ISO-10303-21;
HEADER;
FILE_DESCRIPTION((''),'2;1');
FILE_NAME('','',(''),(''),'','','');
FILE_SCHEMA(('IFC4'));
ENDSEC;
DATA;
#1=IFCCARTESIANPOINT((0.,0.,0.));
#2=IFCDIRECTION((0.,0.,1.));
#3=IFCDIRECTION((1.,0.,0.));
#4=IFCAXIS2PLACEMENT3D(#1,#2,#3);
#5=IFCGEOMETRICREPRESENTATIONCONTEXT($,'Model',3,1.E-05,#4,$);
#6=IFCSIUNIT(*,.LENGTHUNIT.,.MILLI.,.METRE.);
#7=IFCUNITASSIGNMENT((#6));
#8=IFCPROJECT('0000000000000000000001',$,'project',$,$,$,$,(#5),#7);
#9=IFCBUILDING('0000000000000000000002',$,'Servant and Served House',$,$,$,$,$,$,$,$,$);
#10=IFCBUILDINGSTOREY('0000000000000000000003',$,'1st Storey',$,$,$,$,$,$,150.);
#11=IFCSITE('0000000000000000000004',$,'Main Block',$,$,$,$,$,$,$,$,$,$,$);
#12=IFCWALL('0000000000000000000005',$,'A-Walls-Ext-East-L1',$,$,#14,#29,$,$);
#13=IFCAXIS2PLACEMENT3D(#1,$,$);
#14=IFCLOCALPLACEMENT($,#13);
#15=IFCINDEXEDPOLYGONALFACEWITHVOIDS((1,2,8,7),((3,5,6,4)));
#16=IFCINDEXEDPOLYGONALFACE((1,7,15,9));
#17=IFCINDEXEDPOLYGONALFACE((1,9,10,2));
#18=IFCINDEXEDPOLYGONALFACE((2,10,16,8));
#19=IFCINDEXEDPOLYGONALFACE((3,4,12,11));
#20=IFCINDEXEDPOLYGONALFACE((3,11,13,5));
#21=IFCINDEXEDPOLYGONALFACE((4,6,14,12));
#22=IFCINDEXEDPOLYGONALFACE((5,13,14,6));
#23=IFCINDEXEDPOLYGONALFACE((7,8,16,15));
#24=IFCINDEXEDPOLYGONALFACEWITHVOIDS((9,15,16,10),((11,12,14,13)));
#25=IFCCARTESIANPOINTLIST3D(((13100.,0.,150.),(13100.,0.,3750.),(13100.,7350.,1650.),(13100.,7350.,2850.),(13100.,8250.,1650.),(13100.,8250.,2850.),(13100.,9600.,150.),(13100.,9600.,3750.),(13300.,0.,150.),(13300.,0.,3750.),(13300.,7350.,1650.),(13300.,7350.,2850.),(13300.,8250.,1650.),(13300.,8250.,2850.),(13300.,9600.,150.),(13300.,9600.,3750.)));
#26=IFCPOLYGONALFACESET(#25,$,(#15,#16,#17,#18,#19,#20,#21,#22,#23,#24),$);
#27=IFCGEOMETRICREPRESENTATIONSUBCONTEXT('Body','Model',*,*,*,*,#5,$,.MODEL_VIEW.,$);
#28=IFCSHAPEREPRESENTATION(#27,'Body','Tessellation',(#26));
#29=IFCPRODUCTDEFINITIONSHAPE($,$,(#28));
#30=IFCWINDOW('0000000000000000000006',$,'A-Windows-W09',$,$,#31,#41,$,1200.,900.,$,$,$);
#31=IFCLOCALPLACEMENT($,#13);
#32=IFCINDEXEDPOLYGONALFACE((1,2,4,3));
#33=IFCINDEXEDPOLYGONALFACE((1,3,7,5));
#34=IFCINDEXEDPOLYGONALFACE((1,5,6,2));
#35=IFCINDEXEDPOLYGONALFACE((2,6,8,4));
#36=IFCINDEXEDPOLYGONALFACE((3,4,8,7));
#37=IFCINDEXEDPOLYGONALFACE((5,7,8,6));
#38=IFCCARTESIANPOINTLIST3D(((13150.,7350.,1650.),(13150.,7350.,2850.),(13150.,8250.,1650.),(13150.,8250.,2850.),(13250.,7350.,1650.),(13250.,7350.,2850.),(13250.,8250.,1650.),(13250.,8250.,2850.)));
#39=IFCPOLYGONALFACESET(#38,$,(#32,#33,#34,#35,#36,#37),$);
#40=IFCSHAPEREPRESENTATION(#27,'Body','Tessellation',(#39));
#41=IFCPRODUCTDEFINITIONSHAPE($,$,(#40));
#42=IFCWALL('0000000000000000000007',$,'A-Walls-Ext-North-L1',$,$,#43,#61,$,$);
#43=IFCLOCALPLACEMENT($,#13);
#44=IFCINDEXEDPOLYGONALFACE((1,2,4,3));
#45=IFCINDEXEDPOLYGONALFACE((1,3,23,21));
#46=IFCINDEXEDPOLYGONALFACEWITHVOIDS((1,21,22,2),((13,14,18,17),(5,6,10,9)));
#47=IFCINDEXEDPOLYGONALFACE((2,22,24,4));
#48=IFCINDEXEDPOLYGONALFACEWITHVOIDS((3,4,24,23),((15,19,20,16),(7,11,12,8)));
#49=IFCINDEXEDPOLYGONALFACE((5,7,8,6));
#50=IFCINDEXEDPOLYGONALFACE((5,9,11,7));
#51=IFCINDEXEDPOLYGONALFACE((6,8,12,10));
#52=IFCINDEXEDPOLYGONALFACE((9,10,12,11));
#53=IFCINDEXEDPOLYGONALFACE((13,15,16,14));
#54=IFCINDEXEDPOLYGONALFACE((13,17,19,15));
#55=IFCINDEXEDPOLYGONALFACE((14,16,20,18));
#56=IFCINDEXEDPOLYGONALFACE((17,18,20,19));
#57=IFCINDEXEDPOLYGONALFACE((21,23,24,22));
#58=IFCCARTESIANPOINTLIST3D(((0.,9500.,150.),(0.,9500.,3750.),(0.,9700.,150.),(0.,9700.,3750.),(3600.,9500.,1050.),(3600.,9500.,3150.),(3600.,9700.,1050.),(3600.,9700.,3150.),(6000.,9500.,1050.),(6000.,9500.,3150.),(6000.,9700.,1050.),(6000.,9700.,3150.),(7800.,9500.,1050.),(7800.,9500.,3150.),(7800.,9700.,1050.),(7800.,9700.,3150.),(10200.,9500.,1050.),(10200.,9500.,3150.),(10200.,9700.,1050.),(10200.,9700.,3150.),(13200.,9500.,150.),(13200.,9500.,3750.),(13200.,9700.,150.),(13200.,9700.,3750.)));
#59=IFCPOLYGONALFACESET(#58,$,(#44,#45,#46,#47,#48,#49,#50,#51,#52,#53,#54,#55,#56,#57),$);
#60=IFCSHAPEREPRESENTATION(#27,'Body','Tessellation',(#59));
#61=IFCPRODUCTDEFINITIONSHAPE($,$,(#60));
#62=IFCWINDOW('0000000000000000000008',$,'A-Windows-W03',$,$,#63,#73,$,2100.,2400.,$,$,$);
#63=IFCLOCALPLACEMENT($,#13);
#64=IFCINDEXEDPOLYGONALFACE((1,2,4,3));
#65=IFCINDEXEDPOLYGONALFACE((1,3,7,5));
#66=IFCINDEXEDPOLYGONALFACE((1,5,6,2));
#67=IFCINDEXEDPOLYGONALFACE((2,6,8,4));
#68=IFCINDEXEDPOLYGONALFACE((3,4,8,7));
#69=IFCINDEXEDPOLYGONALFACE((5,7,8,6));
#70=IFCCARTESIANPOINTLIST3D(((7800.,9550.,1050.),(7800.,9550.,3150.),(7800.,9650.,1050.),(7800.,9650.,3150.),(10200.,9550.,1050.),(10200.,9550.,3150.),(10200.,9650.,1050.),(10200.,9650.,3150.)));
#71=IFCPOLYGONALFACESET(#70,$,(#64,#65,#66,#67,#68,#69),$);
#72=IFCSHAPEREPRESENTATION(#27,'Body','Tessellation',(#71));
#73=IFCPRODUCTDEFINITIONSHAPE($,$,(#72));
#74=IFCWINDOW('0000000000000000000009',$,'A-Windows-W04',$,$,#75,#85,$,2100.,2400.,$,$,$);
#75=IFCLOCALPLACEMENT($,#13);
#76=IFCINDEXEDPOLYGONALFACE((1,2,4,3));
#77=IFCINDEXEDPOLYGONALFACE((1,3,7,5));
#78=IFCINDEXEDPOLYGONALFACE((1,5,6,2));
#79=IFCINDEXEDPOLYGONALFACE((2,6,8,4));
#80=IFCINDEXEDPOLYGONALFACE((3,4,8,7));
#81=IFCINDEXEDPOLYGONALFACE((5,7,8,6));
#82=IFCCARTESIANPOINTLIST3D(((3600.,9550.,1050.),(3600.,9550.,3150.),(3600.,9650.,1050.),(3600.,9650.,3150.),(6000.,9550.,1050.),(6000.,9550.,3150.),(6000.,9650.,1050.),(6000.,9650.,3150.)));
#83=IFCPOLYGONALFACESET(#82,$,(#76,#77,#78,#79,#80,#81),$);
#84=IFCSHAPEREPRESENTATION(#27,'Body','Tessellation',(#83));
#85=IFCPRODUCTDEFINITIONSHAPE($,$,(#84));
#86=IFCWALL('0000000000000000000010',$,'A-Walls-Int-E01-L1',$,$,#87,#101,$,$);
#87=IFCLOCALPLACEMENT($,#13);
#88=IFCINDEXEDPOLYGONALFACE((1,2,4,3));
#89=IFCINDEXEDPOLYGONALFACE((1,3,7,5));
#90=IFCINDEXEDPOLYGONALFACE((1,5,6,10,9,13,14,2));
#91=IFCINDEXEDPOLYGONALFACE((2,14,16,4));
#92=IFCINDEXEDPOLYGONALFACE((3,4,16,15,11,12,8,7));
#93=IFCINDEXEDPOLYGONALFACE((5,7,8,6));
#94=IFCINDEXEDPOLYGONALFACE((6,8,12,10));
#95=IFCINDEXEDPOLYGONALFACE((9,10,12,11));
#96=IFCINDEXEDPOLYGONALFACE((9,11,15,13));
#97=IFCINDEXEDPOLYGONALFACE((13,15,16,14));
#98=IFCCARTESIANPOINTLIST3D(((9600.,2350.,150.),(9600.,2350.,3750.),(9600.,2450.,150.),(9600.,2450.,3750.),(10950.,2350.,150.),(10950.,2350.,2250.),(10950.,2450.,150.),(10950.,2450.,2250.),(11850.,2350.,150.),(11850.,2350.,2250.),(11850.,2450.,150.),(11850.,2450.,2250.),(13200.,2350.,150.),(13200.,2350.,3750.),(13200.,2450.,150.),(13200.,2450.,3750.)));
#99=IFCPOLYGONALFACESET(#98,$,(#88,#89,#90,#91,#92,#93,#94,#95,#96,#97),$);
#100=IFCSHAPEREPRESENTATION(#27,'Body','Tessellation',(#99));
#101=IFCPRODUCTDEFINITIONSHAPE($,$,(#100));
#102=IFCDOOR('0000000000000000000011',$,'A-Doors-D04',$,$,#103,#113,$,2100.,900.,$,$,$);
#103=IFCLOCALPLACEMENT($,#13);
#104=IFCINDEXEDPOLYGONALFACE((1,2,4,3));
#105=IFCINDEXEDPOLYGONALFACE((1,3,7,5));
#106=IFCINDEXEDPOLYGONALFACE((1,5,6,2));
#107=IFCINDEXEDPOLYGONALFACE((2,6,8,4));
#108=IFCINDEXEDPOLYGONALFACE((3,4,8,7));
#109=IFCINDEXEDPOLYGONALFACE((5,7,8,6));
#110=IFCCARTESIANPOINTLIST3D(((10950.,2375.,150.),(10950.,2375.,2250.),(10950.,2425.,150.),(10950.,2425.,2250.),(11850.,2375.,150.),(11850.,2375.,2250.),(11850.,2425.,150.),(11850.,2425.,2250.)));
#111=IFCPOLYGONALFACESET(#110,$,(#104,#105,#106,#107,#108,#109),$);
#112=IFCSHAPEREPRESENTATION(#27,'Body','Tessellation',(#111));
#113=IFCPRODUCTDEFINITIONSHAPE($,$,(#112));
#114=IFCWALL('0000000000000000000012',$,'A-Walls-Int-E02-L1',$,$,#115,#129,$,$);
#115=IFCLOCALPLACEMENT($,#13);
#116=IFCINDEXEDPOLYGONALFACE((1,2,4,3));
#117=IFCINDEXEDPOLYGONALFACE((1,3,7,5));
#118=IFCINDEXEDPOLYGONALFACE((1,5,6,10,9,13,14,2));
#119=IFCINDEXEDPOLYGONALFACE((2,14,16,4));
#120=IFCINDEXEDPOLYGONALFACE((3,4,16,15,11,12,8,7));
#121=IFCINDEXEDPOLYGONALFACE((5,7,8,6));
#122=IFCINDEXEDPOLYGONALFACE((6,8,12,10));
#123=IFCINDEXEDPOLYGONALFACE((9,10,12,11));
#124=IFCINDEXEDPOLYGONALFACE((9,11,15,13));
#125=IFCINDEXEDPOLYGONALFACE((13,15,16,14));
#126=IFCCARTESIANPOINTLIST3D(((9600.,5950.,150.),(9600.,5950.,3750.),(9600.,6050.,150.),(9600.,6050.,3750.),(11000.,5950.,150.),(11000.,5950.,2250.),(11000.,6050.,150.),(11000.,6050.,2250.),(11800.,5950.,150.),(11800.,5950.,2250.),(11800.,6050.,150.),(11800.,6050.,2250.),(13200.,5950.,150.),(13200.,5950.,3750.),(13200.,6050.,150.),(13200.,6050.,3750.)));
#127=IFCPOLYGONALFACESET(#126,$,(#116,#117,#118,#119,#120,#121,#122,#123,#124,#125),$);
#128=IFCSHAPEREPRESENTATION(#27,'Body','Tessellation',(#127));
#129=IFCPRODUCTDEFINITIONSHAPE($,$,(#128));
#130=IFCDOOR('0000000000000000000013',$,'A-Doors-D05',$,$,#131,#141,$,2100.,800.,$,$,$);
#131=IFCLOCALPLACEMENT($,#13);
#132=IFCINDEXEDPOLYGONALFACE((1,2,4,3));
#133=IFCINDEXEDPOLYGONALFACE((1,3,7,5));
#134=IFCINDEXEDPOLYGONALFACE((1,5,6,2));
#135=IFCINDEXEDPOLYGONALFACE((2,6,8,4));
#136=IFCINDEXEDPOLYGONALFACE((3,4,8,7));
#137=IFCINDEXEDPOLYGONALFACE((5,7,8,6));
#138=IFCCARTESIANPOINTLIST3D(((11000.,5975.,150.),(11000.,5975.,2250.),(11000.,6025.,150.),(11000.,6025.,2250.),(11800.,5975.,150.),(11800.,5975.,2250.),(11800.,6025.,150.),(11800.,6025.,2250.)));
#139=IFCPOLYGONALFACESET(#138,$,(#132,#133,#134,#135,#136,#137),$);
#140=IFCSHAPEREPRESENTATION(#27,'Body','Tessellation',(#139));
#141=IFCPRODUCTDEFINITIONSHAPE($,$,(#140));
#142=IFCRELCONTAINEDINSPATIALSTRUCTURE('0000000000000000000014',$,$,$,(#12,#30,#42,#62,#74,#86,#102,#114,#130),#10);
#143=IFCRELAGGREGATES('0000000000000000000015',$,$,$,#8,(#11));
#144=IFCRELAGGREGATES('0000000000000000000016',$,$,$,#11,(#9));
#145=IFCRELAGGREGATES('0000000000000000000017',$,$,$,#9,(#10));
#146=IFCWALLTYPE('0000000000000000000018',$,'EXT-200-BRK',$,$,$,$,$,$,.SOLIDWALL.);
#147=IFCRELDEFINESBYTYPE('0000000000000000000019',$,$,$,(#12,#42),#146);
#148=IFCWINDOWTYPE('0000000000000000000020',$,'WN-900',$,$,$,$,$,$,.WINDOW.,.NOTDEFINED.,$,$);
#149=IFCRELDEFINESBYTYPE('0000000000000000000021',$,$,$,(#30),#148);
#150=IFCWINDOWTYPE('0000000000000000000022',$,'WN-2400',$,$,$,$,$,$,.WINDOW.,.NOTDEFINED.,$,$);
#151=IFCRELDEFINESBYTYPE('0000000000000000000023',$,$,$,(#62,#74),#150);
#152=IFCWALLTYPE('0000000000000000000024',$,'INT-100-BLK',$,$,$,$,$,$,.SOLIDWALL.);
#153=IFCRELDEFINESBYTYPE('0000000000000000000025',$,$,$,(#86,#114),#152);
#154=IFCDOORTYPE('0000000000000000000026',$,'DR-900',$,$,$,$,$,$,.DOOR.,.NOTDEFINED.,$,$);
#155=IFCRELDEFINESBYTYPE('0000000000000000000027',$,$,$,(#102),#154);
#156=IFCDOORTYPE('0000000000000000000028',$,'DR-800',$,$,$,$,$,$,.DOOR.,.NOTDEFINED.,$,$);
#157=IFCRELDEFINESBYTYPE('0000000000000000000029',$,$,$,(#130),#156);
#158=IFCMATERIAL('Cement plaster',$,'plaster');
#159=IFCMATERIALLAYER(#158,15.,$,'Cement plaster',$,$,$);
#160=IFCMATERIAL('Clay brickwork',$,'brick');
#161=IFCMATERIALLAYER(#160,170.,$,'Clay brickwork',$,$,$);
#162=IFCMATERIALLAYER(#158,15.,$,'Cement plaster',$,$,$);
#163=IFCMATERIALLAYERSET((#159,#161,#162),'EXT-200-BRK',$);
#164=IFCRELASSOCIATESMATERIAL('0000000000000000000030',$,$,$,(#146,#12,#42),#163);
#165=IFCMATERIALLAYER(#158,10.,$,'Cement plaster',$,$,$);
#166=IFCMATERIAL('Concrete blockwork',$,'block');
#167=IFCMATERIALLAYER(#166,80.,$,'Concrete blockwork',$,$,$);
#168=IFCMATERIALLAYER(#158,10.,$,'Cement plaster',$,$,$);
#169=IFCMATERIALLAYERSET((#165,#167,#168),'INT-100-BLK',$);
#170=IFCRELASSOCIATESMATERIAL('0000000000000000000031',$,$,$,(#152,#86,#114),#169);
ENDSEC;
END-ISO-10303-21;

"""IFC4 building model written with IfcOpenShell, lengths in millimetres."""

from ifc_helpers import new_model, si_unit, frame, origin_with_axes, place, context, subcontext, project, spatial, indexed_curve, outline, extrude, material, layer, layer_set, layer_usage, type_object, element, fill, save


model = new_model("IFC4")

# Units and contexts
model_context = context("Model", 3, precision=1e-05, world=origin_with_axes())
body_context = subcontext(model_context, "Body", "Model", "MODEL_VIEW")
ifc_project = project(units=[si_unit("LENGTHUNIT", "METRE", prefix="MILLI")], contexts=[model_context])

# Site, building, storey
site = spatial("IfcSite", under=ifc_project, Name="Main Block")
building = spatial("IfcBuilding", under=site, Name="Servant and Served House")
storey = spatial("IfcBuildingStorey", under=building, Name="1st Storey", Elevation=150.0)

# Wall, opening, window
ifc_material_1 = material(Name="Cement plaster", Category="plaster")
ifc_layer_1 = layer(ifc_material_1, 15.0, Name="Cement plaster")
ifc_material_2 = material(Name="Clay brickwork", Category="brick")
ifc_layer_2 = layer(ifc_material_2, 170.0, Name="Clay brickwork")
ifc_layer_3 = layer(ifc_material_1, 15.0, Name="Cement plaster")
ifc_layer_set_1 = layer_set([ifc_layer_1, ifc_layer_2, ifc_layer_3], Name="EXT-200-BRK")
ifc_layer_usage_1 = layer_usage(ifc_layer_set_1, "AXIS2", "POSITIVE", 0.0)
wall_type_1 = type_object("IfcWallType", Name="EXT-200-BRK", PredefinedType="SOLIDWALL", material=ifc_layer_set_1)
wall_1_placement = place(None, frame((13300.0, 0.0, 150.0), z_axis=(0.0, 0.0, 1.0), x_axis=(0.0, 1.0, 0.0)))
wall_1 = element("IfcWall", 1, at=wall_1_placement, inside=storey, type_object=wall_type_1, material=ifc_layer_usage_1, Name="A-Walls-Ext-East-L1", context=body_context, shape_type="SweptSolid", body=[
    extrude(outline(indexed_curve([(0.0, 0.0), (0.0, 200.0), (9600.0, 200.0), (9600.0, 0.0), (0.0, 0.0)], self_intersect=False)), origin_with_axes(), (0.0, 0.0, 1.0), 3600.0),
])
opening_1_placement = place(wall_1_placement, frame((7800.0, 100.0, 1500.0), z_axis=(0.0, 0.0, 1.0), x_axis=(1.0, 0.0, 0.0)))
opening_1 = element("IfcOpeningElement", 2, at=opening_1_placement, cuts=wall_1, PredefinedType="OPENING", context=body_context, shape_type="SweptSolid", body=[
    extrude(outline(indexed_curve([(-450.0, -150.0), (450.0, -150.0), (450.0, 150.0), (-450.0, 150.0)])), None, (0.0, 0.0, 1.0), 1200.0),
])
window_type_1 = type_object("IfcWindowType", Name="WN-900", PartitioningType="NOTDEFINED", PredefinedType="WINDOW")
window_1_placement = place(None, frame((13200.0, 7800.0, 1650.0), z_axis=(0.0, 0.0, 1.0), x_axis=(0.0, 1.0, 0.0)))
window_1 = element("IfcWindow", 3, at=window_1_placement, inside=storey, type_object=window_type_1, Name="A-Windows-W09", OverallHeight=1200.0, OverallWidth=900.0, context=body_context, shape_type="SweptSolid", body=[
    extrude(outline(indexed_curve([(-450.0, -50.0), (450.0, -50.0), (450.0, 50.0), (-450.0, 50.0)])), None, (0.0, 0.0, 1.0), 1200.0),
])
fill(opening_1, window_1)

# Wall, openings, windows
ifc_layer_usage_2 = layer_usage(ifc_layer_set_1, "AXIS2", "POSITIVE", 0.0)
wall_2_placement = place(None, frame((13200.0, 9700.0, 150.0), z_axis=(0.0, 0.0, 1.0), x_axis=(-1.0, 0.0, 0.0)))
wall_2 = element("IfcWall", 4, at=wall_2_placement, inside=storey, type_object=wall_type_1, material=ifc_layer_usage_2, Name="A-Walls-Ext-North-L1", context=body_context, shape_type="SweptSolid", body=[
    extrude(outline(indexed_curve([(0.0, 0.0), (0.0, 200.0), (13200.0, 200.0), (13200.0, 0.0), (0.0, 0.0)], self_intersect=False)), origin_with_axes(), (0.0, 0.0, 1.0), 3600.0),
])
opening_2_placement = place(wall_2_placement, frame((4200.0, 100.0, 900.0), z_axis=(0.0, 0.0, 1.0), x_axis=(1.0, 0.0, 0.0)))
opening_2 = element("IfcOpeningElement", 5, at=opening_2_placement, cuts=wall_2, PredefinedType="OPENING", context=body_context, shape_type="SweptSolid", body=[
    extrude(outline(indexed_curve([(-1200.0, -150.0), (1200.0, -150.0), (1200.0, 150.0), (-1200.0, 150.0)])), None, (0.0, 0.0, 1.0), 2100.0),
])
opening_3_placement = place(wall_2_placement, frame((8400.0, 100.0, 900.0), z_axis=(0.0, 0.0, 1.0), x_axis=(1.0, 0.0, 0.0)))
opening_3 = element("IfcOpeningElement", 6, at=opening_3_placement, cuts=wall_2, PredefinedType="OPENING", context=body_context, shape_type="SweptSolid", body=[
    extrude(outline(indexed_curve([(-1200.0, -150.0), (1200.0, -150.0), (1200.0, 150.0), (-1200.0, 150.0)])), None, (0.0, 0.0, 1.0), 2100.0),
])
window_type_2 = type_object("IfcWindowType", Name="WN-2400", PartitioningType="NOTDEFINED", PredefinedType="WINDOW")
window_2_placement = place(None, frame((9000.0, 9600.0, 1050.0), z_axis=(0.0, 0.0, 1.0), x_axis=(-1.0, 0.0, 0.0)))
window_2 = element("IfcWindow", 7, at=window_2_placement, inside=storey, type_object=window_type_2, Name="A-Windows-W03", OverallHeight=2100.0, OverallWidth=2400.0, context=body_context, shape_type="SweptSolid", body=[
    extrude(outline(indexed_curve([(-1200.0, -50.0), (1200.0, -50.0), (1200.0, 50.0), (-1200.0, 50.0)])), None, (0.0, 0.0, 1.0), 2100.0),
])
fill(opening_2, window_2)
window_3_placement = place(None, frame((4800.0, 9600.0, 1050.0), z_axis=(0.0, 0.0, 1.0), x_axis=(-1.0, 0.0, 0.0)))
window_3 = element("IfcWindow", 8, at=window_3_placement, inside=storey, type_object=window_type_2, Name="A-Windows-W04", OverallHeight=2100.0, OverallWidth=2400.0, context=body_context, shape_type="SweptSolid", body=[
    extrude(outline(indexed_curve([(-1200.0, -50.0), (1200.0, -50.0), (1200.0, 50.0), (-1200.0, 50.0)])), None, (0.0, 0.0, 1.0), 2100.0),
])
fill(opening_3, window_3)

# Walls, openings, doors
ifc_layer_4 = layer(ifc_material_1, 10.0, Name="Cement plaster")
ifc_material_3 = material(Name="Concrete blockwork", Category="block")
ifc_layer_5 = layer(ifc_material_3, 80.0, Name="Concrete blockwork")
ifc_layer_6 = layer(ifc_material_1, 10.0, Name="Cement plaster")
ifc_layer_set_2 = layer_set([ifc_layer_4, ifc_layer_5, ifc_layer_6], Name="INT-100-BLK")
ifc_layer_usage_3 = layer_usage(ifc_layer_set_2, "AXIS2", "POSITIVE", 0.0)
wall_type_2 = type_object("IfcWallType", Name="INT-100-BLK", PredefinedType="SOLIDWALL", material=ifc_layer_set_2)
wall_3_placement = place(None, frame((9600.0, 2350.0, 150.0), z_axis=(0.0, 0.0, 1.0), x_axis=(1.0, 0.0, 0.0)))
wall_3 = element("IfcWall", 9, at=wall_3_placement, inside=storey, type_object=wall_type_2, material=ifc_layer_usage_3, Name="A-Walls-Int-E01-L1", context=body_context, shape_type="SweptSolid", body=[
    extrude(outline(indexed_curve([(0.0, 0.0), (0.0, 100.0), (3600.0, 100.0), (3600.0, 0.0), (0.0, 0.0)], self_intersect=False)), origin_with_axes(), (0.0, 0.0, 1.0), 3600.0),
])
opening_4_placement = place(wall_3_placement, frame((1800.0, 50.0, 0.0), z_axis=(0.0, 0.0, 1.0), x_axis=(1.0, 0.0, 0.0)))
opening_4 = element("IfcOpeningElement", 10, at=opening_4_placement, cuts=wall_3, PredefinedType="OPENING", context=body_context, shape_type="SweptSolid", body=[
    extrude(outline(indexed_curve([(-450.0, -100.0), (450.0, -100.0), (450.0, 100.0), (-450.0, 100.0)])), None, (0.0, 0.0, 1.0), 2100.0),
])
door_type_1 = type_object("IfcDoorType", Name="DR-900", OperationType="NOTDEFINED", PredefinedType="DOOR")
door_1_placement = place(None, frame((11400.0, 2400.0, 150.0), z_axis=(0.0, 0.0, 1.0), x_axis=(1.0, 0.0, 0.0)))
door_1 = element("IfcDoor", 11, at=door_1_placement, inside=storey, type_object=door_type_1, Name="A-Doors-D04", OverallHeight=2100.0, OverallWidth=900.0, context=body_context, shape_type="SweptSolid", body=[
    extrude(outline(indexed_curve([(-450.0, -25.0), (450.0, -25.0), (450.0, 25.0), (-450.0, 25.0)])), None, (0.0, 0.0, 1.0), 2100.0),
])
fill(opening_4, door_1)
ifc_layer_usage_4 = layer_usage(ifc_layer_set_2, "AXIS2", "POSITIVE", 0.0)
wall_4_placement = place(None, frame((9600.0, 5950.0, 150.0), z_axis=(0.0, 0.0, 1.0), x_axis=(1.0, 0.0, 0.0)))
wall_4 = element("IfcWall", 12, at=wall_4_placement, inside=storey, type_object=wall_type_2, material=ifc_layer_usage_4, Name="A-Walls-Int-E02-L1", context=body_context, shape_type="SweptSolid", body=[
    extrude(outline(indexed_curve([(0.0, 0.0), (0.0, 100.0), (3600.0, 100.0), (3600.0, 0.0), (0.0, 0.0)], self_intersect=False)), origin_with_axes(), (0.0, 0.0, 1.0), 3600.0),
])
opening_5_placement = place(wall_4_placement, frame((1800.0, 50.0, 0.0), z_axis=(0.0, 0.0, 1.0), x_axis=(1.0, 0.0, 0.0)))
opening_5 = element("IfcOpeningElement", 13, at=opening_5_placement, cuts=wall_4, PredefinedType="OPENING", context=body_context, shape_type="SweptSolid", body=[
    extrude(outline(indexed_curve([(-400.0, -100.0), (400.0, -100.0), (400.0, 100.0), (-400.0, 100.0)])), None, (0.0, 0.0, 1.0), 2100.0),
])
door_type_2 = type_object("IfcDoorType", Name="DR-800", OperationType="NOTDEFINED", PredefinedType="DOOR")
door_2_placement = place(None, frame((11400.0, 6000.0, 150.0), z_axis=(0.0, 0.0, 1.0), x_axis=(1.0, 0.0, 0.0)))
door_2 = element("IfcDoor", 14, at=door_2_placement, inside=storey, type_object=door_type_2, Name="A-Doors-D05", OverallHeight=2100.0, OverallWidth=800.0, context=body_context, shape_type="SweptSolid", body=[
    extrude(outline(indexed_curve([(-400.0, -25.0), (400.0, -25.0), (400.0, 25.0), (-400.0, 25.0)])), None, (0.0, 0.0, 1.0), 2100.0),
])
fill(opening_5, door_2)

save(model, "model.ifc")
